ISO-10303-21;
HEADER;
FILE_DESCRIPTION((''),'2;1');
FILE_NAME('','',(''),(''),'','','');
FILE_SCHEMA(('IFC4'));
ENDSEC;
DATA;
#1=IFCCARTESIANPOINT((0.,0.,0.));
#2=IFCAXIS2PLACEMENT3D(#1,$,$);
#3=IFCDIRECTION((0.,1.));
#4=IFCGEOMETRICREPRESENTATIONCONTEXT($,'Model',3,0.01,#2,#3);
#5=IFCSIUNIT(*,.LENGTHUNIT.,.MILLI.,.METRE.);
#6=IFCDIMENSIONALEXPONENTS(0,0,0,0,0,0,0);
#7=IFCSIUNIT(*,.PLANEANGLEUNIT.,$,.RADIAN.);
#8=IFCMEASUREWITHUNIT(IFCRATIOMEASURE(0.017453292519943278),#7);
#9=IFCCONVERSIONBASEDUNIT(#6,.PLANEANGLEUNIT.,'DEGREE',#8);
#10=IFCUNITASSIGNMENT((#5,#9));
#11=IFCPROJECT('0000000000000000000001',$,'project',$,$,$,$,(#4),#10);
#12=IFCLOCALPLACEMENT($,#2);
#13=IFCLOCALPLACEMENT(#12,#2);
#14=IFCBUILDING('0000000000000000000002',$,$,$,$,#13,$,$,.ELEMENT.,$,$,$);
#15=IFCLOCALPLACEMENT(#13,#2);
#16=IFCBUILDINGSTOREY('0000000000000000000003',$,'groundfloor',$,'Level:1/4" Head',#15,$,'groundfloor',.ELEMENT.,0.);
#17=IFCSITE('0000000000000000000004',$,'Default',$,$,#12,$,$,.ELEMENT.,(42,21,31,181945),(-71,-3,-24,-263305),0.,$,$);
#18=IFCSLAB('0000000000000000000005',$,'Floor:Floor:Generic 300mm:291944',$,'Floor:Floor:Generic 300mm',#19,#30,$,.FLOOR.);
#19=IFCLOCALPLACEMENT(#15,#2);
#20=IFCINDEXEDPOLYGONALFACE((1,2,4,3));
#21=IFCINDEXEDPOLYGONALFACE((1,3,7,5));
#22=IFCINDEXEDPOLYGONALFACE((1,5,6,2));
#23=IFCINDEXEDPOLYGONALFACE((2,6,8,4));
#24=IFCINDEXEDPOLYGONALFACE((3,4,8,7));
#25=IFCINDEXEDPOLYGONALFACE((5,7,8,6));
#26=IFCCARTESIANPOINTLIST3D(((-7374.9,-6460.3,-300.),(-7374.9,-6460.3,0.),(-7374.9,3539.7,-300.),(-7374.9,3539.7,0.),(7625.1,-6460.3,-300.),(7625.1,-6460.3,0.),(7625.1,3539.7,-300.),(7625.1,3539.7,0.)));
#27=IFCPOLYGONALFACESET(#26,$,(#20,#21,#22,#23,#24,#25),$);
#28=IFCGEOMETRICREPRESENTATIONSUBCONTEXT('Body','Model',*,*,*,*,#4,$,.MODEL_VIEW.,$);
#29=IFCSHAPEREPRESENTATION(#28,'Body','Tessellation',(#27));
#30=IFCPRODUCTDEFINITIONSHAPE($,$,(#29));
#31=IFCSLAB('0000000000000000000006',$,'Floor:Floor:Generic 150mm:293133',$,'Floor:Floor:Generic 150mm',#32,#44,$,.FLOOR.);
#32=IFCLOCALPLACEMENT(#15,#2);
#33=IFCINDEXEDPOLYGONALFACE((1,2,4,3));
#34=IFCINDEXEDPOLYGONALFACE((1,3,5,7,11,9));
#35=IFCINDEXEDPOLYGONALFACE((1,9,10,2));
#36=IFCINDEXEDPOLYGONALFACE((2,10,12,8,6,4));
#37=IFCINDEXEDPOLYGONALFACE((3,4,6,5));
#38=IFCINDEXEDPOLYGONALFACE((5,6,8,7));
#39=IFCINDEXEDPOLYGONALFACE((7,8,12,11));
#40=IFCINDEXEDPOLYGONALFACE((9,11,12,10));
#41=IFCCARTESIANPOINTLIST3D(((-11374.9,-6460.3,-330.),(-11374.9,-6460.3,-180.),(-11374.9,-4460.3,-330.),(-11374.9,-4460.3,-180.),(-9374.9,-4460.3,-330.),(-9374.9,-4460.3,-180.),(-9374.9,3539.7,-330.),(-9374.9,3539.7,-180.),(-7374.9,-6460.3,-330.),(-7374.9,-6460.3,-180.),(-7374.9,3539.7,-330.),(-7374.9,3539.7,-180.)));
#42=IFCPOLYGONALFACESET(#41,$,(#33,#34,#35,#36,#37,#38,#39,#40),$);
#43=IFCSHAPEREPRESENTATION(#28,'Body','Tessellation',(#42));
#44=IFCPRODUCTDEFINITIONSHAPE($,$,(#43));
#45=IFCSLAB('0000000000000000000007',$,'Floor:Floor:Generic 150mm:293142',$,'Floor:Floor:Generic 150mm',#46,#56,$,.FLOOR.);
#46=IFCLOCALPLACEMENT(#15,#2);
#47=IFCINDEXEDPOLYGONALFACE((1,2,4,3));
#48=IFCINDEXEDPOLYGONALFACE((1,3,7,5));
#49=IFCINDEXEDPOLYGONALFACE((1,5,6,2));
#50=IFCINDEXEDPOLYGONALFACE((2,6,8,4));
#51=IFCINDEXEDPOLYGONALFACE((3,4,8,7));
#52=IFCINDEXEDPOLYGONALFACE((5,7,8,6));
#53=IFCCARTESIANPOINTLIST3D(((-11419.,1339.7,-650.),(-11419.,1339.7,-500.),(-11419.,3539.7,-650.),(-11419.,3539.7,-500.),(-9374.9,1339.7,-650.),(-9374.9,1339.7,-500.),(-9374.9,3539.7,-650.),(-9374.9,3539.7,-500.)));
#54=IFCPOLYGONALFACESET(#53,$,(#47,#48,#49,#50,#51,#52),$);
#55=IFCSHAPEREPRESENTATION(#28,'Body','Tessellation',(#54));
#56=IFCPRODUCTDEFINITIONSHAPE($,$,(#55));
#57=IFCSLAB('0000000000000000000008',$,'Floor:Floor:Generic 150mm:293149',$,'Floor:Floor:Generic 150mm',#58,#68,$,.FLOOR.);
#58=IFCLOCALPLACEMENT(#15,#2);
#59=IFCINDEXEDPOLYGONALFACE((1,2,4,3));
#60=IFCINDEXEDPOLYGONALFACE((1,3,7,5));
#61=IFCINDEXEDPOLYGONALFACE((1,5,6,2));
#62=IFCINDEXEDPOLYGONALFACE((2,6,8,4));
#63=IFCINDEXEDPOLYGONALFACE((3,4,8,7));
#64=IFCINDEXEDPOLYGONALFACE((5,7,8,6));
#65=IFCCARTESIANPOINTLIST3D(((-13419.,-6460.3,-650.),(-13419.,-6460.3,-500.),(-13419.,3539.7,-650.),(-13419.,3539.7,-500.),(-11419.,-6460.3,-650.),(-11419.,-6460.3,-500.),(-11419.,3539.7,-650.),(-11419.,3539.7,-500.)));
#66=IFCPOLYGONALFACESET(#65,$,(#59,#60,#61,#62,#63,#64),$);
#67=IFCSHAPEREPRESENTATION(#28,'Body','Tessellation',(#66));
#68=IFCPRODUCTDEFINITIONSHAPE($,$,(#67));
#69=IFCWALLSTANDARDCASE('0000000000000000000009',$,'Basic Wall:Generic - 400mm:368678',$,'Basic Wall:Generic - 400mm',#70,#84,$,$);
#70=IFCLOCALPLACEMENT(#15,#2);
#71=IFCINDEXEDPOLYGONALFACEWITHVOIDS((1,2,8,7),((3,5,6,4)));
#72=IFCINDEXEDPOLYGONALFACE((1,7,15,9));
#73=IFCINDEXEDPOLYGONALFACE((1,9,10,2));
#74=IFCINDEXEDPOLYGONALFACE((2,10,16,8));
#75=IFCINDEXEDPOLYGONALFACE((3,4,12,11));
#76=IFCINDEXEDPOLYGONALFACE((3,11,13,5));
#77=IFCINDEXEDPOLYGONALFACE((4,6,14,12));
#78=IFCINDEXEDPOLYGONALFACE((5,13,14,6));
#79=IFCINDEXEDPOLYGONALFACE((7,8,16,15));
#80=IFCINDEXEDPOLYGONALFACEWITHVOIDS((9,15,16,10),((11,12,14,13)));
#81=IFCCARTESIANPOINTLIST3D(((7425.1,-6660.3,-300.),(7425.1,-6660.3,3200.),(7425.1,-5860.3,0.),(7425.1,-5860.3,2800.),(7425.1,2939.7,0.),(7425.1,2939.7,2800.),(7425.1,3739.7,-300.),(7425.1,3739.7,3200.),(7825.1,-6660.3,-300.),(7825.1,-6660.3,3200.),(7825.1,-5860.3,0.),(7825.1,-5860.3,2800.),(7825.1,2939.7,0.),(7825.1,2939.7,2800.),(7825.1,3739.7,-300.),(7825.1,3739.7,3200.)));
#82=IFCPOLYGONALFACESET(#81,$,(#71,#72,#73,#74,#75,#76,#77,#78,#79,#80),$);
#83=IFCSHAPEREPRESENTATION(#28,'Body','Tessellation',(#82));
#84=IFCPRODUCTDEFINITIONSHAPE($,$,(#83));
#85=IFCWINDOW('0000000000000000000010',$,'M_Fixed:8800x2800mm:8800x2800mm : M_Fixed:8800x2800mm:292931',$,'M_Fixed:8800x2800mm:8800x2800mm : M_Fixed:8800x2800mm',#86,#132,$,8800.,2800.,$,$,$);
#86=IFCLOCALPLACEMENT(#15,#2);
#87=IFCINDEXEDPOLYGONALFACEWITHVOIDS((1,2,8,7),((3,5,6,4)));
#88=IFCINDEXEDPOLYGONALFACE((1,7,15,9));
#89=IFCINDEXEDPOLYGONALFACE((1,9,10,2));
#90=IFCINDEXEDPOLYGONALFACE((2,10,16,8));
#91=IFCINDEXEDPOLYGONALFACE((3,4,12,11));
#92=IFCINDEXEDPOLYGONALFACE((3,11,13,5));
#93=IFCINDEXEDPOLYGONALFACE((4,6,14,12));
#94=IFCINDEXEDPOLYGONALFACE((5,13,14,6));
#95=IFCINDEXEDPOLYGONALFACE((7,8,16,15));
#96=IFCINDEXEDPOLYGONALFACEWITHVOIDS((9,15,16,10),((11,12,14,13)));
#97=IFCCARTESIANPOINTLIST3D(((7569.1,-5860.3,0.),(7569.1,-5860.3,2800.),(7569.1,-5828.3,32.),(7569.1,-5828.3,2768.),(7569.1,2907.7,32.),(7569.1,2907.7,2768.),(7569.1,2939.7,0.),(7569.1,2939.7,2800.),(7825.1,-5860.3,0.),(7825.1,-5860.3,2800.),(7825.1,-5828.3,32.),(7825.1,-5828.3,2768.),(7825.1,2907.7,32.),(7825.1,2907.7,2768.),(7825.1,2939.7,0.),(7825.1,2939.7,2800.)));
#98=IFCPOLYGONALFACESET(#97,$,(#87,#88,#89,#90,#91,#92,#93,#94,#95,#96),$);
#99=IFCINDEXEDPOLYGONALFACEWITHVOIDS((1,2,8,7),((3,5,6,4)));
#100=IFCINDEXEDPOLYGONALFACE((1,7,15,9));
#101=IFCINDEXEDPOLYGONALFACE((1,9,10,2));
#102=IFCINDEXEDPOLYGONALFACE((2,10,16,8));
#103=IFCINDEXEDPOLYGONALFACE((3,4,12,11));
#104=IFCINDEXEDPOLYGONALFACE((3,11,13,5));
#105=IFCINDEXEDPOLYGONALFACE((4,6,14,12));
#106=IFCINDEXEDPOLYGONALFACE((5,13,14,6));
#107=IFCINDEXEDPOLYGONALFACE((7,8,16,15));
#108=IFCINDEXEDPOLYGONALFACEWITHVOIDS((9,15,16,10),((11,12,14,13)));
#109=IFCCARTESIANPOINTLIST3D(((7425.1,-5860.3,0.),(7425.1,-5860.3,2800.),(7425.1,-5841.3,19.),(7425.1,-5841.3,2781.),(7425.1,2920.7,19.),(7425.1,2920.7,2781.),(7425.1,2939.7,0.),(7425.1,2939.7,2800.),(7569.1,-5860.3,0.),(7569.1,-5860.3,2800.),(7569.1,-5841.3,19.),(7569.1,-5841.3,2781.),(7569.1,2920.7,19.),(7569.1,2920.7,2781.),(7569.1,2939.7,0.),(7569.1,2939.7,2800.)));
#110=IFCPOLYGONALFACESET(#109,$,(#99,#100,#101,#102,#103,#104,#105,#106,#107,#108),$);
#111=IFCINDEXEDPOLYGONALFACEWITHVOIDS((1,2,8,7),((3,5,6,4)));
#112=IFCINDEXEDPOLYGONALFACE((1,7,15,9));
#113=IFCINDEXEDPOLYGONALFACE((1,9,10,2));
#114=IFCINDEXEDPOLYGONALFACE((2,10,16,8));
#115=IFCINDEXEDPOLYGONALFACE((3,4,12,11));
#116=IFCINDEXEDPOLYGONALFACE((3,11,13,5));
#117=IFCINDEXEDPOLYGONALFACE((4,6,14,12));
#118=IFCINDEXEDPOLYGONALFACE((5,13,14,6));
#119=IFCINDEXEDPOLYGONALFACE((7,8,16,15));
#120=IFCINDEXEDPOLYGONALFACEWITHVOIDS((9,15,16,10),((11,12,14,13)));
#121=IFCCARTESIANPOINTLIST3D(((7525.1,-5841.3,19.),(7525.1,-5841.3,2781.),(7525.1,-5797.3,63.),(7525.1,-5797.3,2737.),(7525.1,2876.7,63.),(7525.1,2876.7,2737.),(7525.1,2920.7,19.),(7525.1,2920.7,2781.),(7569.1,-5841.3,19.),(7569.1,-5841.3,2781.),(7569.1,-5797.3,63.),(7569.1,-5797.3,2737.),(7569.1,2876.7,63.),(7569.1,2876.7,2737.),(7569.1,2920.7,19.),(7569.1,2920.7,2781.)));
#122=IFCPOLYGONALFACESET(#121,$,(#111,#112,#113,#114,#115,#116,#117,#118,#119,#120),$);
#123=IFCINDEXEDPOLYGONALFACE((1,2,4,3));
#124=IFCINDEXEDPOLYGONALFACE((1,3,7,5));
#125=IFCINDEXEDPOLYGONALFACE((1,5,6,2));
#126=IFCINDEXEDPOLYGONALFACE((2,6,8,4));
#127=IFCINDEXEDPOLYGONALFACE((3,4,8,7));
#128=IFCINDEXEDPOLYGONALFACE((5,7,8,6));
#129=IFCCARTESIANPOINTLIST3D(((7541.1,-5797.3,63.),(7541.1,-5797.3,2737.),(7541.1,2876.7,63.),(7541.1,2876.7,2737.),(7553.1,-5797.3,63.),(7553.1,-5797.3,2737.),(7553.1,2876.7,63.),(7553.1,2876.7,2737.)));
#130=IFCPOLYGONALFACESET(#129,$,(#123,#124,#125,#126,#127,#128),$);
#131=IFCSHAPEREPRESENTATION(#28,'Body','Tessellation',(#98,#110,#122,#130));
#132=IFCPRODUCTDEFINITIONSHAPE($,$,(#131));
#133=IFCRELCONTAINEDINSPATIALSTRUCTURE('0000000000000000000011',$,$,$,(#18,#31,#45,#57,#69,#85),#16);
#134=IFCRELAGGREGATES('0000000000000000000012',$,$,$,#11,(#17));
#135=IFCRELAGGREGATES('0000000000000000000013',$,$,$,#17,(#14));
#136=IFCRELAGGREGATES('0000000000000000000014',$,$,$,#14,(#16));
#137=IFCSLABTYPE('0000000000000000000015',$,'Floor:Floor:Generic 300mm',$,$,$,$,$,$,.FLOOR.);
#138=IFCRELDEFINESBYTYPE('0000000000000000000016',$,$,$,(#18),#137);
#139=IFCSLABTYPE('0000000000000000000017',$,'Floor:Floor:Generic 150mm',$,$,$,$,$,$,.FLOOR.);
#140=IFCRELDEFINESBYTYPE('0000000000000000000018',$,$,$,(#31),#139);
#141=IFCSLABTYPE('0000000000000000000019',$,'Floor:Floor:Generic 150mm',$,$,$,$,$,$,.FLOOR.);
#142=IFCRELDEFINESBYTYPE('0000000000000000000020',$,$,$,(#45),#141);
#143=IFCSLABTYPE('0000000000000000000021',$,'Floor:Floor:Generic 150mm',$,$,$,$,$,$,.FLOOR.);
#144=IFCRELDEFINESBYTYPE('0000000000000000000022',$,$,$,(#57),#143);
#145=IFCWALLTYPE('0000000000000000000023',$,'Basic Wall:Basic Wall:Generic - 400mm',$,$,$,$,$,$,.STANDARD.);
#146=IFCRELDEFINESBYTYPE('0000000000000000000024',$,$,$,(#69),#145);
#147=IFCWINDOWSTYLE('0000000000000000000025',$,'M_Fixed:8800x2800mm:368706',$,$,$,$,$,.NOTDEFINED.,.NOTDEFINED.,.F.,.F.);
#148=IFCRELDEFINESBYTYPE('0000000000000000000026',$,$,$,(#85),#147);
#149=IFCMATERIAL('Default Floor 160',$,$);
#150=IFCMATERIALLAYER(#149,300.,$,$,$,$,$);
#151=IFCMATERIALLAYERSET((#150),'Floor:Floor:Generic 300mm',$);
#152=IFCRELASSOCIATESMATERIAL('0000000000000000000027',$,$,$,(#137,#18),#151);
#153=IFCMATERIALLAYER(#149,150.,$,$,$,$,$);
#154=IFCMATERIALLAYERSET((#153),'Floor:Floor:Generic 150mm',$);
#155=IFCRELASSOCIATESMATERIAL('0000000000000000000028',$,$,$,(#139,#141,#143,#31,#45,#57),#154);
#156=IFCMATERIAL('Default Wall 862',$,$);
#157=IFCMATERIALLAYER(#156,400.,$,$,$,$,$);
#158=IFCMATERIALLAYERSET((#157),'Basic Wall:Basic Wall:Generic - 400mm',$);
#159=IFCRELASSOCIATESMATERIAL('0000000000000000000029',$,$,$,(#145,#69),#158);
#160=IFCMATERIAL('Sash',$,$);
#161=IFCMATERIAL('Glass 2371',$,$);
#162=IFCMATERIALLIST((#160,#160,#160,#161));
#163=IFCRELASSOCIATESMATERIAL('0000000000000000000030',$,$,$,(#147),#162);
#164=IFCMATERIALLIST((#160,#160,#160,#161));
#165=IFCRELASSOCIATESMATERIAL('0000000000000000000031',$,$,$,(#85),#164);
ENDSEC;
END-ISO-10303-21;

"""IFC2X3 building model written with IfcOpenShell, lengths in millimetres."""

from ifc_helpers import new_model, entity, si_unit, converted_unit, direction, frame, frame_2d, origin, origin_2d_with_axis, place, context, subcontext, project, spatial, polyline, rectangle, outline, extrude, source, transform, mapped, material, material_list, layer, layer_set, layer_usage, type_object, type_shapes, element, fill, save


model = new_model("IFC2X3")

# Units and contexts
model_context = context("Model", 3, precision=0.01, world=origin(), true_north=direction((0.0, 1.0)))
body_context = subcontext(model_context, "Body", "Model", "MODEL_VIEW")
ifc_project = project(units=[si_unit("LENGTHUNIT", "METRE", prefix="MILLI"), converted_unit("PLANEANGLEUNIT", "DEGREE", entity("IfcRatioMeasure", 0.017453292519943278), si_unit("PLANEANGLEUNIT", "RADIAN"), dimensions=[0, 0, 0, 0, 0, 0, 0])], contexts=[model_context])

# Site, building, storey
site_placement = place(None, origin())
site = spatial("IfcSite", under=ifc_project, at=site_placement, Name="Default", CompositionType="ELEMENT", RefLatitude=(42, 21, 31, 181945), RefLongitude=(-71, -3, -24, -263305), RefElevation=0.0)
building_placement = place(site_placement, origin())
building = spatial("IfcBuilding", under=site, at=building_placement, CompositionType="ELEMENT")
storey_placement = place(building_placement, origin())
storey = spatial("IfcBuildingStorey", under=building, at=storey_placement, Name="groundfloor", ObjectType="Level:1/4\" Head", LongName="groundfloor", CompositionType="ELEMENT", Elevation=0.0)

# Slabs
ifc_material_1 = material(Name="Default Floor 160")
ifc_layer_1 = layer(ifc_material_1, 300.0)
ifc_layer_set_1 = layer_set([ifc_layer_1], Name="Floor:Floor:Generic 300mm")
ifc_layer_usage_1 = layer_usage(ifc_layer_set_1, "AXIS3", "POSITIVE", 0.0)
slab_type_1 = type_object("IfcSlabType", Name="Floor:Floor:Generic 300mm", PredefinedType="FLOOR", material=ifc_layer_set_1)
slab_1_placement = place(storey_placement, origin())
element("IfcSlab", 1, at=slab_1_placement, inside=storey, type_object=slab_type_1, material=ifc_layer_usage_1, Name="Floor:Floor:Generic 300mm:291944", ObjectType="Floor:Floor:Generic 300mm", PredefinedType="FLOOR", context=body_context, shape_type="SweptSolid", body=[
    extrude(rectangle(XDim=10000.0, YDim=15000.0, at=origin_2d_with_axis()), frame((125.1, -1460.3, 0.0), z_axis=(0.0, 0.0, -1.0), x_axis=(0.0, 1.0, 0.0)), (0.0, 0.0, 1.0), 300.0),
])
ifc_layer_2 = layer(ifc_material_1, 150.0)
ifc_layer_set_2 = layer_set([ifc_layer_2], Name="Floor:Floor:Generic 150mm")
ifc_layer_usage_2 = layer_usage(ifc_layer_set_2, "AXIS3", "POSITIVE", 0.0)
slab_type_2 = type_object("IfcSlabType", Name="Floor:Floor:Generic 150mm", PredefinedType="FLOOR", material=ifc_layer_set_2)
slab_2_placement = place(storey_placement, origin())
element("IfcSlab", 2, at=slab_2_placement, inside=storey, type_object=slab_type_2, material=ifc_layer_usage_2, Name="Floor:Floor:Generic 150mm:293133", ObjectType="Floor:Floor:Generic 150mm", PredefinedType="FLOOR", context=body_context, shape_type="SweptSolid", body=[
    extrude(outline(polyline([(-4000.0, -2000.0), (-2000.0, -2000.0), (-2000.0, 0.0), (6000.0, 0.0), (6000.0, 2000.0), (-4000.0, 2000.0), (-4000.0, -2000.0)])), frame((-9374.9, -2460.3, -180.0), z_axis=(0.0, 0.0, -1.0), x_axis=(0.0, 1.0, 0.0)), (0.0, 0.0, 1.0), 150.0),
])
ifc_layer_usage_3 = layer_usage(ifc_layer_set_2, "AXIS3", "POSITIVE", 0.0)
slab_type_3 = type_object("IfcSlabType", Name="Floor:Floor:Generic 150mm", PredefinedType="FLOOR", material=ifc_layer_set_2)
slab_3_placement = place(storey_placement, origin())
element("IfcSlab", 3, at=slab_3_placement, inside=storey, type_object=slab_type_3, material=ifc_layer_usage_3, Name="Floor:Floor:Generic 150mm:293142", ObjectType="Floor:Floor:Generic 150mm", PredefinedType="FLOOR", context=body_context, shape_type="SweptSolid", body=[
    extrude(rectangle(XDim=2200.0, YDim=2044.0, at=frame_2d((0.0, 0.0), x_axis=(1.0, 0.0))), frame((-10397.0, 2439.7, -500.0), z_axis=(0.0, 0.0, -1.0), x_axis=(0.0, 1.0, 0.0)), (0.0, 0.0, 1.0), 150.0),
])
ifc_layer_usage_4 = layer_usage(ifc_layer_set_2, "AXIS3", "POSITIVE", 0.0)
slab_type_4 = type_object("IfcSlabType", Name="Floor:Floor:Generic 150mm", PredefinedType="FLOOR", material=ifc_layer_set_2)
slab_4_placement = place(storey_placement, origin())
element("IfcSlab", 4, at=slab_4_placement, inside=storey, type_object=slab_type_4, material=ifc_layer_usage_4, Name="Floor:Floor:Generic 150mm:293149", ObjectType="Floor:Floor:Generic 150mm", PredefinedType="FLOOR", context=body_context, shape_type="SweptSolid", body=[
    extrude(rectangle(XDim=10000.0, YDim=2000.0, at=origin_2d_with_axis()), frame((-12419.0, -1460.3, -500.0), z_axis=(0.0, 0.0, -1.0), x_axis=(0.0, 1.0, 0.0)), (0.0, 0.0, 1.0), 150.0),
])

# Wall, openings, window
ifc_material_2 = material(Name="Default Wall 862")
ifc_layer_3 = layer(ifc_material_2, 400.0)
ifc_layer_set_3 = layer_set([ifc_layer_3], Name="Basic Wall:Basic Wall:Generic - 400mm")
ifc_layer_usage_5 = layer_usage(ifc_layer_set_3, "AXIS2", "NEGATIVE", 200.0)
wall_type_1 = type_object("IfcWallType", Name="Basic Wall:Basic Wall:Generic - 400mm", PredefinedType="STANDARD", material=ifc_layer_set_3)
wall_1_placement = place(storey_placement, frame((7625.1, 3739.7, -300.0), z_axis=(0.0, 0.0, 1.0), x_axis=(0.0, -1.0, 0.0)))
wall_1 = element("IfcWallStandardCase", 5, at=wall_1_placement, inside=storey, type_object=wall_type_1, material=ifc_layer_usage_5, Name="Basic Wall:Generic - 400mm:368678", ObjectType="Basic Wall:Generic - 400mm", context=body_context, shape_type="SweptSolid", body=[
    extrude(rectangle(XDim=10400.0, YDim=400.0, at=frame_2d((5200.0, 0.0), x_axis=(-1.0, 0.0))), origin(), (0.0, 0.0, 1.0), 3500.0),
])
opening_1_placement = place(wall_1_placement, origin())
element("IfcOpeningElement", 6, at=opening_1_placement, cuts=wall_1, ObjectType="Opening", context=body_context, shape_type="SweptSolid", body=[
    extrude(rectangle(XDim=2500.0, YDim=1000.0, at=origin_2d_with_axis()), frame((1700.0, -200.0, 4750.0), z_axis=(0.0, 1.0, 0.0), x_axis=(0.0, 0.0, -1.0)), (0.0, 0.0, 1.0), 400.0),
])
opening_2_placement = place(wall_1_placement, origin())
element("IfcOpeningElement", 7, at=opening_2_placement, cuts=wall_1, ObjectType="Opening", context=body_context, shape_type="SweptSolid", body=[
    extrude(rectangle(XDim=2500.0, YDim=1000.0, at=origin_2d_with_axis()), frame((3100.0, -200.0, 4750.0), z_axis=(0.0, 1.0, 0.0), x_axis=(0.0, 0.0, -1.0)), (0.0, 0.0, 1.0), 400.0),
])
opening_3_placement = place(wall_1_placement, origin())
element("IfcOpeningElement", 8, at=opening_3_placement, cuts=wall_1, ObjectType="Opening", context=body_context, shape_type="SweptSolid", body=[
    extrude(rectangle(XDim=2500.0, YDim=1000.0, at=origin_2d_with_axis()), frame((4500.0, -200.0, 4750.0), z_axis=(0.0, 1.0, 0.0), x_axis=(0.0, 0.0, -1.0)), (0.0, 0.0, 1.0), 400.0),
])
opening_4_placement = place(wall_1_placement, origin())
element("IfcOpeningElement", 9, at=opening_4_placement, cuts=wall_1, ObjectType="Opening", context=body_context, shape_type="SweptSolid", body=[
    extrude(rectangle(XDim=2500.0, YDim=1000.0, at=origin_2d_with_axis()), frame((5900.0, -200.0, 4750.0), z_axis=(0.0, 1.0, 0.0), x_axis=(0.0, 0.0, -1.0)), (0.0, 0.0, 1.0), 400.0),
])
opening_5_placement = place(wall_1_placement, origin())
element("IfcOpeningElement", 10, at=opening_5_placement, cuts=wall_1, ObjectType="Opening", context=body_context, shape_type="SweptSolid", body=[
    extrude(rectangle(XDim=2500.0, YDim=1000.0, at=origin_2d_with_axis()), frame((7300.0, -200.0, 4750.0), z_axis=(0.0, 1.0, 0.0), x_axis=(0.0, 0.0, -1.0)), (0.0, 0.0, 1.0), 400.0),
])
opening_6_placement = place(wall_1_placement, origin())
element("IfcOpeningElement", 11, at=opening_6_placement, cuts=wall_1, ObjectType="Opening", context=body_context, shape_type="SweptSolid", body=[
    extrude(rectangle(XDim=2500.0, YDim=1000.0, at=frame_2d((0.0, 0.0), x_axis=(1.0, 0.0))), frame((8700.0, -200.0, 4750.0), z_axis=(0.0, 1.0, 0.0), x_axis=(0.0, 0.0, -1.0)), (0.0, 0.0, 1.0), 400.0),
])
opening_7_placement = place(wall_1_placement, frame((3739.7, -7625.1, 300.0), z_axis=(0.0, 0.0, 1.0), x_axis=(0.0, 1.0, 0.0)))
opening_7 = element("IfcOpeningElement", 12, at=opening_7_placement, cuts=wall_1, ObjectType="Opening", context=body_context, shape_type="SweptSolid", body=[
    extrude(rectangle(XDim=2800.0, YDim=8800.0, at=origin_2d_with_axis()), frame((7421.1, -1460.3, 1400.0), z_axis=(1.0, 0.0, 0.0), x_axis=(0.0, 0.0, -1.0)), (0.0, 0.0, 1.0), 408.0),
])
ifc_material_3 = material(Name="Sash")
ifc_material_4 = material(Name="Glass 2371")
ifc_material_list_1 = material_list([ifc_material_3, ifc_material_3, ifc_material_3, ifc_material_4])
ifc_material_list_2 = material_list([ifc_material_3, ifc_material_3, ifc_material_3, ifc_material_4])
window_style_1 = type_object("IfcWindowStyle", Name="M_Fixed:8800x2800mm:368706", ConstructionType="NOTDEFINED", OperationType="NOTDEFINED", ParameterTakesPrecedence=False, Sizeable=False, material=ifc_material_list_2)
shared_shape_1 = source(origin(), body_context, "Body", "SweptSolid", [
    extrude(outline(polyline([(-4400.0, -1400.0), (4400.0, -1400.0), (4400.0, 1400.0), (-4400.0, 1400.0), (-4400.0, -1400.0)]), holes=[polyline([(4368.0, 1368.0), (4368.0, -1368.0), (-4368.0, -1368.0), (-4368.0, 1368.0), (4368.0, 1368.0)])]), frame((4400.0, 4.0, 1400.0), z_axis=(0.0, 1.0, 0.0), x_axis=(1.0, 0.0, 0.0)), (0.0, 0.0, 1.0), 256.0),
    extrude(outline(polyline([(-4400.0, -1400.0), (4400.0, -1400.0), (4400.0, 1400.0), (-4400.0, 1400.0), (-4400.0, -1400.0)]), holes=[polyline([(4381.0, 1381.0), (4381.0, -1381.0), (-4381.0, -1381.0), (-4381.0, 1381.0), (4381.0, 1381.0)])]), frame((4400.0, 260.0, 1400.0), z_axis=(0.0, 1.0, 0.0), x_axis=(1.0, 0.0, 0.0)), (0.0, 0.0, 1.0), 144.0),
    extrude(outline(polyline([(-4381.0, -1381.0), (4381.0, -1381.0), (4381.0, 1381.0), (-4381.0, 1381.0), (-4381.0, -1381.0)]), holes=[polyline([(4337.0, 1337.0), (4337.0, -1337.0), (-4337.0, -1337.0), (-4337.0, 1337.0), (4337.0, 1337.0)])]), frame((4400.0, 260.0, 1400.0), z_axis=(0.0, 1.0, 0.0), x_axis=(1.0, 0.0, 0.0)), (0.0, 0.0, 1.0), 44.0),
    extrude(rectangle(XDim=12.0, YDim=8674.0, at=origin_2d_with_axis()), frame((4400.0, 282.0, 63.0), z_axis=(0.0, 0.0, 1.0), x_axis=(0.0, -1.0, 0.0)), (0.0, 0.0, 1.0), 2674.0),
])
type_shapes(window_style_1, [shared_shape_1])
window_1_placement = place(opening_7_placement, frame((7829.1, -5860.3, 0.0), z_axis=(0.0, 0.0, 1.0), x_axis=(0.0, 1.0, 0.0)))
window_1 = element("IfcWindow", 13, at=window_1_placement, inside=storey, type_object=window_style_1, material=ifc_material_list_1, Name="M_Fixed:8800x2800mm:8800x2800mm : M_Fixed:8800x2800mm:292931", ObjectType="M_Fixed:8800x2800mm:8800x2800mm : M_Fixed:8800x2800mm", OverallHeight=8800.0, OverallWidth=2800.0, context=body_context, shape_type="MappedRepresentation", body=[
    mapped(shared_shape_1, transform((0.0, 0.0, 0.0), scale=1.0)),
])
fill(opening_7, window_1)

save(model, "model.ifc")
